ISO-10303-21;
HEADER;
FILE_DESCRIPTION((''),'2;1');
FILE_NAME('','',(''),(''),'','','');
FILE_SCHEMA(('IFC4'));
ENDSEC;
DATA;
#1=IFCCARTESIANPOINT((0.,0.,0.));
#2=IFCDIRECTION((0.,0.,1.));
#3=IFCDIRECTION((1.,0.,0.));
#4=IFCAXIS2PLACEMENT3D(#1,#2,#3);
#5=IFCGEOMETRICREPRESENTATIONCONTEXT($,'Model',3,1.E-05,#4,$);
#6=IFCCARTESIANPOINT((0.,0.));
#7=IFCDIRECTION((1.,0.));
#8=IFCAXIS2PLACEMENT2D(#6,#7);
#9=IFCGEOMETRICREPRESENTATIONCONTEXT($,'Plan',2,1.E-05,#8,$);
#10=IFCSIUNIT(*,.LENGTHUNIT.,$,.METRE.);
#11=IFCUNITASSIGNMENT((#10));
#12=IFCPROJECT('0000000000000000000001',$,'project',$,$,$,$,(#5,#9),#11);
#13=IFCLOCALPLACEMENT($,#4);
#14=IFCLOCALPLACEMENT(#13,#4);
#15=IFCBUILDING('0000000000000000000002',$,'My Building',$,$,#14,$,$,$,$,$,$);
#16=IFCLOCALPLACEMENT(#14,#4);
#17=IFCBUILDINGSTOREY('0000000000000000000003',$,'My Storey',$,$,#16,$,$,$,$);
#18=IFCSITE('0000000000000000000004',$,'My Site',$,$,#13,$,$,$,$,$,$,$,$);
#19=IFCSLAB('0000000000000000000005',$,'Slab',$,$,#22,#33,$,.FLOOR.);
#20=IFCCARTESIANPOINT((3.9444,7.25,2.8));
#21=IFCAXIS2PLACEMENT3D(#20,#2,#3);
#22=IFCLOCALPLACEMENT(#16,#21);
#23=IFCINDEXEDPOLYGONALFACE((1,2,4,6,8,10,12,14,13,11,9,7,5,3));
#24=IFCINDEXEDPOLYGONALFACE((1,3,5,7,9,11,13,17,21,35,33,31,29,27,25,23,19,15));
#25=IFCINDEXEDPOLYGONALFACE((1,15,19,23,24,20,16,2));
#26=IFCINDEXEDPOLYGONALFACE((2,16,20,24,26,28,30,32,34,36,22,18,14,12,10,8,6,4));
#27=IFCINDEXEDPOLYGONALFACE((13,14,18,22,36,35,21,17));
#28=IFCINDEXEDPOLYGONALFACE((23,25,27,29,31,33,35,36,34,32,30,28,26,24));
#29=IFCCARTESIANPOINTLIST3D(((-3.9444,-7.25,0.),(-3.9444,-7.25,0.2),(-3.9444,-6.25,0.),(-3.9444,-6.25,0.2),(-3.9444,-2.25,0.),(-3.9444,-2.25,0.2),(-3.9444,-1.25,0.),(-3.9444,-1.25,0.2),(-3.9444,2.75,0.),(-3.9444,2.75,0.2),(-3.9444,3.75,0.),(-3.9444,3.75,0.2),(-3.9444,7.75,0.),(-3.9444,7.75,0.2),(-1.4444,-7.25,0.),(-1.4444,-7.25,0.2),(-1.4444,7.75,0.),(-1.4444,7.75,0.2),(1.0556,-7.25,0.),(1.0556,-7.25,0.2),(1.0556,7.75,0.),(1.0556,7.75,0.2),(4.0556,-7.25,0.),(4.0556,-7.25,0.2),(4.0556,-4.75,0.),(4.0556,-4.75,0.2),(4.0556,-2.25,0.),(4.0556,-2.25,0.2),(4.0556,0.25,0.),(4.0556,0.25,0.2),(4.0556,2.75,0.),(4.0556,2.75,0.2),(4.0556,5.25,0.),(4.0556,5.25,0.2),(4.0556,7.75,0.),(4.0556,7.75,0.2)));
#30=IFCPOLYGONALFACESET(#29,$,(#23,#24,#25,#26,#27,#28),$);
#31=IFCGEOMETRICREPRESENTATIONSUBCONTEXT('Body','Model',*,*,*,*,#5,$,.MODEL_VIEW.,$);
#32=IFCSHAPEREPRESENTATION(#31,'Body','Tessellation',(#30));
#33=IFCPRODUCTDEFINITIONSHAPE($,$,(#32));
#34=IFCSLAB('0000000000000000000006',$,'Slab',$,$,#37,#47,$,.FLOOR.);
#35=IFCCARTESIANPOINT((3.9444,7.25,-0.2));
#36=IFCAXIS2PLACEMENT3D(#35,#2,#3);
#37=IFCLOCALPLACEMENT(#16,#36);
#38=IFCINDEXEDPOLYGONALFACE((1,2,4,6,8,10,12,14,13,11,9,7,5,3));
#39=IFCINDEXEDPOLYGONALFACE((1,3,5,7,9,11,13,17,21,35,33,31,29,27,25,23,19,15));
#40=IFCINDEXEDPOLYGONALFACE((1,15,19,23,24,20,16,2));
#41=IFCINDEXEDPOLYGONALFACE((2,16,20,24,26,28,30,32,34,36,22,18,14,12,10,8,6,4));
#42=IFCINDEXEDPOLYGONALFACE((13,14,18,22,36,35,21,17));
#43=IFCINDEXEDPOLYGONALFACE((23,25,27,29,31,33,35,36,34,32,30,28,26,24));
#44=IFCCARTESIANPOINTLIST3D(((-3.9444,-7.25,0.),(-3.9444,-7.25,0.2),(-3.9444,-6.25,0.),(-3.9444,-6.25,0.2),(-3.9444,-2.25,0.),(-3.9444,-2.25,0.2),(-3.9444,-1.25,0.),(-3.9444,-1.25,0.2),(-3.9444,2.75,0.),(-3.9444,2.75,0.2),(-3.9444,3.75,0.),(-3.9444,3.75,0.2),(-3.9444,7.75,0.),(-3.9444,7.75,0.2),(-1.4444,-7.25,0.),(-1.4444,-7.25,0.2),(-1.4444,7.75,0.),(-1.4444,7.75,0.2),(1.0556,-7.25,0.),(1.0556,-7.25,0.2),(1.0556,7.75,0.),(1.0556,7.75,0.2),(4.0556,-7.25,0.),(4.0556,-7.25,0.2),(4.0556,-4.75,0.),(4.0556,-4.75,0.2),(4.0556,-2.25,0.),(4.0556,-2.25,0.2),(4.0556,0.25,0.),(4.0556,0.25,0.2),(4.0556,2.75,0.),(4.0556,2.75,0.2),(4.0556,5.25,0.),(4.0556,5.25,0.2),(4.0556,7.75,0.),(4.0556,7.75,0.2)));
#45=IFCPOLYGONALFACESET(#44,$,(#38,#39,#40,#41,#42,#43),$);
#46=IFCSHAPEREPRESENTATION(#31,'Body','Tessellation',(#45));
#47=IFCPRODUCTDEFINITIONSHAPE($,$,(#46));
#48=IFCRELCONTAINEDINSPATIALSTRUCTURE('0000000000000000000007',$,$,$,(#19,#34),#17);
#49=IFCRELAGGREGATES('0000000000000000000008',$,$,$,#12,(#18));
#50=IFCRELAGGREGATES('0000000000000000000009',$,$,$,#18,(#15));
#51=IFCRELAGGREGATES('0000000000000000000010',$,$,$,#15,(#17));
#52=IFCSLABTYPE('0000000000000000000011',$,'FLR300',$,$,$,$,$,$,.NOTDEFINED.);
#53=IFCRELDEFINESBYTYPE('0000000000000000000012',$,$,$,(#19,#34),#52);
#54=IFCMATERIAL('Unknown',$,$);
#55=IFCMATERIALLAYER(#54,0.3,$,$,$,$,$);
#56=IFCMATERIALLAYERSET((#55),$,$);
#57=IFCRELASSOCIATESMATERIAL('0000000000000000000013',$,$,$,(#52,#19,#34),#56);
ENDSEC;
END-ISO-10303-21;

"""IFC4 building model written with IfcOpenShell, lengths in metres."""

from ifc_helpers import new_model, si_unit, frame, origin, origin_with_axes, origin_2d_with_axis, place, context, subcontext, project, spatial, polyline, outline, extrude, material, layer, layer_set, layer_usage, type_object, element, save


model = new_model("IFC4")

# Units and contexts
model_context = context("Model", 3, precision=1e-05, world=origin_with_axes())
plan_context = context("Plan", 2, precision=1e-05, world=origin_2d_with_axis())
body_context = subcontext(model_context, "Body", "Model", "MODEL_VIEW")
ifc_project = project(units=[si_unit("LENGTHUNIT", "METRE")], contexts=[model_context, plan_context])

# Site, building, storey
site_placement = place(None, origin_with_axes())
site = spatial("IfcSite", under=ifc_project, at=site_placement, Name="My Site")
building_placement = place(site_placement, origin_with_axes())
building = spatial("IfcBuilding", under=site, at=building_placement, Name="My Building")
storey_placement = place(building_placement, origin_with_axes())
storey = spatial("IfcBuildingStorey", under=building, at=storey_placement, Name="My Storey")

# Slabs
ifc_material = material(Name="Unknown")
ifc_layer = layer(ifc_material, 0.3)
ifc_layer_set = layer_set([ifc_layer])
ifc_layer_usage_1 = layer_usage(ifc_layer_set, "AXIS3", "POSITIVE", 0.0)
slab_type = type_object("IfcSlabType", Name="FLR300", PredefinedType="NOTDEFINED", material=ifc_layer_set)
slab_1_placement = place(storey_placement, frame((3.9444, 7.25, 2.8), z_axis=(0.0, 0.0, 1.0), x_axis=(1.0, 0.0, 0.0)))
element("IfcSlab", 1, at=slab_1_placement, inside=storey, type_object=slab_type, material=ifc_layer_usage_1, Name="Slab", PredefinedType="FLOOR", context=body_context, shape_type="SweptSolid", body=[
    extrude(outline(polyline([(4.0556, 0.25), (4.0556, 2.75), (4.0556, 5.25), (4.0556, 7.75), (1.0556, 7.75), (-1.4444, 7.75), (-3.9444, 7.75), (-3.9444, 3.75), (-3.9444, 2.75), (-3.9444, -1.25), (-3.9444, -2.25), (-3.9444, -6.25), (-3.9444, -7.25), (-1.4444, -7.25), (1.0556, -7.25), (4.0556, -7.25), (4.0556, -4.75), (4.0556, -2.25), (4.0556, 0.25)])), origin(), (0.0, 0.0, 1.0), 0.2),
])
ifc_layer_usage_2 = layer_usage(ifc_layer_set, "AXIS3", "POSITIVE", 0.0)
slab_2_placement = place(storey_placement, frame((3.9444, 7.25, -0.2), z_axis=(0.0, 0.0, 1.0), x_axis=(1.0, 0.0, 0.0)))
element("IfcSlab", 2, at=slab_2_placement, inside=storey, type_object=slab_type, material=ifc_layer_usage_2, Name="Slab", PredefinedType="FLOOR", context=body_context, shape_type="SweptSolid", body=[
    extrude(outline(polyline([(4.0556, 0.25), (4.0556, 2.75), (4.0556, 5.25), (4.0556, 7.75), (1.0556, 7.75), (-1.4444, 7.75), (-3.9444, 7.75), (-3.9444, 3.75), (-3.9444, 2.75), (-3.9444, -1.25), (-3.9444, -2.25), (-3.9444, -6.25), (-3.9444, -7.25), (-1.4444, -7.25), (1.0556, -7.25), (4.0556, -7.25), (4.0556, -4.75), (4.0556, -2.25), (4.0556, 0.25)])), origin(), (0.0, 0.0, 1.0), 0.2),
])

save(model, "model.ifc")
